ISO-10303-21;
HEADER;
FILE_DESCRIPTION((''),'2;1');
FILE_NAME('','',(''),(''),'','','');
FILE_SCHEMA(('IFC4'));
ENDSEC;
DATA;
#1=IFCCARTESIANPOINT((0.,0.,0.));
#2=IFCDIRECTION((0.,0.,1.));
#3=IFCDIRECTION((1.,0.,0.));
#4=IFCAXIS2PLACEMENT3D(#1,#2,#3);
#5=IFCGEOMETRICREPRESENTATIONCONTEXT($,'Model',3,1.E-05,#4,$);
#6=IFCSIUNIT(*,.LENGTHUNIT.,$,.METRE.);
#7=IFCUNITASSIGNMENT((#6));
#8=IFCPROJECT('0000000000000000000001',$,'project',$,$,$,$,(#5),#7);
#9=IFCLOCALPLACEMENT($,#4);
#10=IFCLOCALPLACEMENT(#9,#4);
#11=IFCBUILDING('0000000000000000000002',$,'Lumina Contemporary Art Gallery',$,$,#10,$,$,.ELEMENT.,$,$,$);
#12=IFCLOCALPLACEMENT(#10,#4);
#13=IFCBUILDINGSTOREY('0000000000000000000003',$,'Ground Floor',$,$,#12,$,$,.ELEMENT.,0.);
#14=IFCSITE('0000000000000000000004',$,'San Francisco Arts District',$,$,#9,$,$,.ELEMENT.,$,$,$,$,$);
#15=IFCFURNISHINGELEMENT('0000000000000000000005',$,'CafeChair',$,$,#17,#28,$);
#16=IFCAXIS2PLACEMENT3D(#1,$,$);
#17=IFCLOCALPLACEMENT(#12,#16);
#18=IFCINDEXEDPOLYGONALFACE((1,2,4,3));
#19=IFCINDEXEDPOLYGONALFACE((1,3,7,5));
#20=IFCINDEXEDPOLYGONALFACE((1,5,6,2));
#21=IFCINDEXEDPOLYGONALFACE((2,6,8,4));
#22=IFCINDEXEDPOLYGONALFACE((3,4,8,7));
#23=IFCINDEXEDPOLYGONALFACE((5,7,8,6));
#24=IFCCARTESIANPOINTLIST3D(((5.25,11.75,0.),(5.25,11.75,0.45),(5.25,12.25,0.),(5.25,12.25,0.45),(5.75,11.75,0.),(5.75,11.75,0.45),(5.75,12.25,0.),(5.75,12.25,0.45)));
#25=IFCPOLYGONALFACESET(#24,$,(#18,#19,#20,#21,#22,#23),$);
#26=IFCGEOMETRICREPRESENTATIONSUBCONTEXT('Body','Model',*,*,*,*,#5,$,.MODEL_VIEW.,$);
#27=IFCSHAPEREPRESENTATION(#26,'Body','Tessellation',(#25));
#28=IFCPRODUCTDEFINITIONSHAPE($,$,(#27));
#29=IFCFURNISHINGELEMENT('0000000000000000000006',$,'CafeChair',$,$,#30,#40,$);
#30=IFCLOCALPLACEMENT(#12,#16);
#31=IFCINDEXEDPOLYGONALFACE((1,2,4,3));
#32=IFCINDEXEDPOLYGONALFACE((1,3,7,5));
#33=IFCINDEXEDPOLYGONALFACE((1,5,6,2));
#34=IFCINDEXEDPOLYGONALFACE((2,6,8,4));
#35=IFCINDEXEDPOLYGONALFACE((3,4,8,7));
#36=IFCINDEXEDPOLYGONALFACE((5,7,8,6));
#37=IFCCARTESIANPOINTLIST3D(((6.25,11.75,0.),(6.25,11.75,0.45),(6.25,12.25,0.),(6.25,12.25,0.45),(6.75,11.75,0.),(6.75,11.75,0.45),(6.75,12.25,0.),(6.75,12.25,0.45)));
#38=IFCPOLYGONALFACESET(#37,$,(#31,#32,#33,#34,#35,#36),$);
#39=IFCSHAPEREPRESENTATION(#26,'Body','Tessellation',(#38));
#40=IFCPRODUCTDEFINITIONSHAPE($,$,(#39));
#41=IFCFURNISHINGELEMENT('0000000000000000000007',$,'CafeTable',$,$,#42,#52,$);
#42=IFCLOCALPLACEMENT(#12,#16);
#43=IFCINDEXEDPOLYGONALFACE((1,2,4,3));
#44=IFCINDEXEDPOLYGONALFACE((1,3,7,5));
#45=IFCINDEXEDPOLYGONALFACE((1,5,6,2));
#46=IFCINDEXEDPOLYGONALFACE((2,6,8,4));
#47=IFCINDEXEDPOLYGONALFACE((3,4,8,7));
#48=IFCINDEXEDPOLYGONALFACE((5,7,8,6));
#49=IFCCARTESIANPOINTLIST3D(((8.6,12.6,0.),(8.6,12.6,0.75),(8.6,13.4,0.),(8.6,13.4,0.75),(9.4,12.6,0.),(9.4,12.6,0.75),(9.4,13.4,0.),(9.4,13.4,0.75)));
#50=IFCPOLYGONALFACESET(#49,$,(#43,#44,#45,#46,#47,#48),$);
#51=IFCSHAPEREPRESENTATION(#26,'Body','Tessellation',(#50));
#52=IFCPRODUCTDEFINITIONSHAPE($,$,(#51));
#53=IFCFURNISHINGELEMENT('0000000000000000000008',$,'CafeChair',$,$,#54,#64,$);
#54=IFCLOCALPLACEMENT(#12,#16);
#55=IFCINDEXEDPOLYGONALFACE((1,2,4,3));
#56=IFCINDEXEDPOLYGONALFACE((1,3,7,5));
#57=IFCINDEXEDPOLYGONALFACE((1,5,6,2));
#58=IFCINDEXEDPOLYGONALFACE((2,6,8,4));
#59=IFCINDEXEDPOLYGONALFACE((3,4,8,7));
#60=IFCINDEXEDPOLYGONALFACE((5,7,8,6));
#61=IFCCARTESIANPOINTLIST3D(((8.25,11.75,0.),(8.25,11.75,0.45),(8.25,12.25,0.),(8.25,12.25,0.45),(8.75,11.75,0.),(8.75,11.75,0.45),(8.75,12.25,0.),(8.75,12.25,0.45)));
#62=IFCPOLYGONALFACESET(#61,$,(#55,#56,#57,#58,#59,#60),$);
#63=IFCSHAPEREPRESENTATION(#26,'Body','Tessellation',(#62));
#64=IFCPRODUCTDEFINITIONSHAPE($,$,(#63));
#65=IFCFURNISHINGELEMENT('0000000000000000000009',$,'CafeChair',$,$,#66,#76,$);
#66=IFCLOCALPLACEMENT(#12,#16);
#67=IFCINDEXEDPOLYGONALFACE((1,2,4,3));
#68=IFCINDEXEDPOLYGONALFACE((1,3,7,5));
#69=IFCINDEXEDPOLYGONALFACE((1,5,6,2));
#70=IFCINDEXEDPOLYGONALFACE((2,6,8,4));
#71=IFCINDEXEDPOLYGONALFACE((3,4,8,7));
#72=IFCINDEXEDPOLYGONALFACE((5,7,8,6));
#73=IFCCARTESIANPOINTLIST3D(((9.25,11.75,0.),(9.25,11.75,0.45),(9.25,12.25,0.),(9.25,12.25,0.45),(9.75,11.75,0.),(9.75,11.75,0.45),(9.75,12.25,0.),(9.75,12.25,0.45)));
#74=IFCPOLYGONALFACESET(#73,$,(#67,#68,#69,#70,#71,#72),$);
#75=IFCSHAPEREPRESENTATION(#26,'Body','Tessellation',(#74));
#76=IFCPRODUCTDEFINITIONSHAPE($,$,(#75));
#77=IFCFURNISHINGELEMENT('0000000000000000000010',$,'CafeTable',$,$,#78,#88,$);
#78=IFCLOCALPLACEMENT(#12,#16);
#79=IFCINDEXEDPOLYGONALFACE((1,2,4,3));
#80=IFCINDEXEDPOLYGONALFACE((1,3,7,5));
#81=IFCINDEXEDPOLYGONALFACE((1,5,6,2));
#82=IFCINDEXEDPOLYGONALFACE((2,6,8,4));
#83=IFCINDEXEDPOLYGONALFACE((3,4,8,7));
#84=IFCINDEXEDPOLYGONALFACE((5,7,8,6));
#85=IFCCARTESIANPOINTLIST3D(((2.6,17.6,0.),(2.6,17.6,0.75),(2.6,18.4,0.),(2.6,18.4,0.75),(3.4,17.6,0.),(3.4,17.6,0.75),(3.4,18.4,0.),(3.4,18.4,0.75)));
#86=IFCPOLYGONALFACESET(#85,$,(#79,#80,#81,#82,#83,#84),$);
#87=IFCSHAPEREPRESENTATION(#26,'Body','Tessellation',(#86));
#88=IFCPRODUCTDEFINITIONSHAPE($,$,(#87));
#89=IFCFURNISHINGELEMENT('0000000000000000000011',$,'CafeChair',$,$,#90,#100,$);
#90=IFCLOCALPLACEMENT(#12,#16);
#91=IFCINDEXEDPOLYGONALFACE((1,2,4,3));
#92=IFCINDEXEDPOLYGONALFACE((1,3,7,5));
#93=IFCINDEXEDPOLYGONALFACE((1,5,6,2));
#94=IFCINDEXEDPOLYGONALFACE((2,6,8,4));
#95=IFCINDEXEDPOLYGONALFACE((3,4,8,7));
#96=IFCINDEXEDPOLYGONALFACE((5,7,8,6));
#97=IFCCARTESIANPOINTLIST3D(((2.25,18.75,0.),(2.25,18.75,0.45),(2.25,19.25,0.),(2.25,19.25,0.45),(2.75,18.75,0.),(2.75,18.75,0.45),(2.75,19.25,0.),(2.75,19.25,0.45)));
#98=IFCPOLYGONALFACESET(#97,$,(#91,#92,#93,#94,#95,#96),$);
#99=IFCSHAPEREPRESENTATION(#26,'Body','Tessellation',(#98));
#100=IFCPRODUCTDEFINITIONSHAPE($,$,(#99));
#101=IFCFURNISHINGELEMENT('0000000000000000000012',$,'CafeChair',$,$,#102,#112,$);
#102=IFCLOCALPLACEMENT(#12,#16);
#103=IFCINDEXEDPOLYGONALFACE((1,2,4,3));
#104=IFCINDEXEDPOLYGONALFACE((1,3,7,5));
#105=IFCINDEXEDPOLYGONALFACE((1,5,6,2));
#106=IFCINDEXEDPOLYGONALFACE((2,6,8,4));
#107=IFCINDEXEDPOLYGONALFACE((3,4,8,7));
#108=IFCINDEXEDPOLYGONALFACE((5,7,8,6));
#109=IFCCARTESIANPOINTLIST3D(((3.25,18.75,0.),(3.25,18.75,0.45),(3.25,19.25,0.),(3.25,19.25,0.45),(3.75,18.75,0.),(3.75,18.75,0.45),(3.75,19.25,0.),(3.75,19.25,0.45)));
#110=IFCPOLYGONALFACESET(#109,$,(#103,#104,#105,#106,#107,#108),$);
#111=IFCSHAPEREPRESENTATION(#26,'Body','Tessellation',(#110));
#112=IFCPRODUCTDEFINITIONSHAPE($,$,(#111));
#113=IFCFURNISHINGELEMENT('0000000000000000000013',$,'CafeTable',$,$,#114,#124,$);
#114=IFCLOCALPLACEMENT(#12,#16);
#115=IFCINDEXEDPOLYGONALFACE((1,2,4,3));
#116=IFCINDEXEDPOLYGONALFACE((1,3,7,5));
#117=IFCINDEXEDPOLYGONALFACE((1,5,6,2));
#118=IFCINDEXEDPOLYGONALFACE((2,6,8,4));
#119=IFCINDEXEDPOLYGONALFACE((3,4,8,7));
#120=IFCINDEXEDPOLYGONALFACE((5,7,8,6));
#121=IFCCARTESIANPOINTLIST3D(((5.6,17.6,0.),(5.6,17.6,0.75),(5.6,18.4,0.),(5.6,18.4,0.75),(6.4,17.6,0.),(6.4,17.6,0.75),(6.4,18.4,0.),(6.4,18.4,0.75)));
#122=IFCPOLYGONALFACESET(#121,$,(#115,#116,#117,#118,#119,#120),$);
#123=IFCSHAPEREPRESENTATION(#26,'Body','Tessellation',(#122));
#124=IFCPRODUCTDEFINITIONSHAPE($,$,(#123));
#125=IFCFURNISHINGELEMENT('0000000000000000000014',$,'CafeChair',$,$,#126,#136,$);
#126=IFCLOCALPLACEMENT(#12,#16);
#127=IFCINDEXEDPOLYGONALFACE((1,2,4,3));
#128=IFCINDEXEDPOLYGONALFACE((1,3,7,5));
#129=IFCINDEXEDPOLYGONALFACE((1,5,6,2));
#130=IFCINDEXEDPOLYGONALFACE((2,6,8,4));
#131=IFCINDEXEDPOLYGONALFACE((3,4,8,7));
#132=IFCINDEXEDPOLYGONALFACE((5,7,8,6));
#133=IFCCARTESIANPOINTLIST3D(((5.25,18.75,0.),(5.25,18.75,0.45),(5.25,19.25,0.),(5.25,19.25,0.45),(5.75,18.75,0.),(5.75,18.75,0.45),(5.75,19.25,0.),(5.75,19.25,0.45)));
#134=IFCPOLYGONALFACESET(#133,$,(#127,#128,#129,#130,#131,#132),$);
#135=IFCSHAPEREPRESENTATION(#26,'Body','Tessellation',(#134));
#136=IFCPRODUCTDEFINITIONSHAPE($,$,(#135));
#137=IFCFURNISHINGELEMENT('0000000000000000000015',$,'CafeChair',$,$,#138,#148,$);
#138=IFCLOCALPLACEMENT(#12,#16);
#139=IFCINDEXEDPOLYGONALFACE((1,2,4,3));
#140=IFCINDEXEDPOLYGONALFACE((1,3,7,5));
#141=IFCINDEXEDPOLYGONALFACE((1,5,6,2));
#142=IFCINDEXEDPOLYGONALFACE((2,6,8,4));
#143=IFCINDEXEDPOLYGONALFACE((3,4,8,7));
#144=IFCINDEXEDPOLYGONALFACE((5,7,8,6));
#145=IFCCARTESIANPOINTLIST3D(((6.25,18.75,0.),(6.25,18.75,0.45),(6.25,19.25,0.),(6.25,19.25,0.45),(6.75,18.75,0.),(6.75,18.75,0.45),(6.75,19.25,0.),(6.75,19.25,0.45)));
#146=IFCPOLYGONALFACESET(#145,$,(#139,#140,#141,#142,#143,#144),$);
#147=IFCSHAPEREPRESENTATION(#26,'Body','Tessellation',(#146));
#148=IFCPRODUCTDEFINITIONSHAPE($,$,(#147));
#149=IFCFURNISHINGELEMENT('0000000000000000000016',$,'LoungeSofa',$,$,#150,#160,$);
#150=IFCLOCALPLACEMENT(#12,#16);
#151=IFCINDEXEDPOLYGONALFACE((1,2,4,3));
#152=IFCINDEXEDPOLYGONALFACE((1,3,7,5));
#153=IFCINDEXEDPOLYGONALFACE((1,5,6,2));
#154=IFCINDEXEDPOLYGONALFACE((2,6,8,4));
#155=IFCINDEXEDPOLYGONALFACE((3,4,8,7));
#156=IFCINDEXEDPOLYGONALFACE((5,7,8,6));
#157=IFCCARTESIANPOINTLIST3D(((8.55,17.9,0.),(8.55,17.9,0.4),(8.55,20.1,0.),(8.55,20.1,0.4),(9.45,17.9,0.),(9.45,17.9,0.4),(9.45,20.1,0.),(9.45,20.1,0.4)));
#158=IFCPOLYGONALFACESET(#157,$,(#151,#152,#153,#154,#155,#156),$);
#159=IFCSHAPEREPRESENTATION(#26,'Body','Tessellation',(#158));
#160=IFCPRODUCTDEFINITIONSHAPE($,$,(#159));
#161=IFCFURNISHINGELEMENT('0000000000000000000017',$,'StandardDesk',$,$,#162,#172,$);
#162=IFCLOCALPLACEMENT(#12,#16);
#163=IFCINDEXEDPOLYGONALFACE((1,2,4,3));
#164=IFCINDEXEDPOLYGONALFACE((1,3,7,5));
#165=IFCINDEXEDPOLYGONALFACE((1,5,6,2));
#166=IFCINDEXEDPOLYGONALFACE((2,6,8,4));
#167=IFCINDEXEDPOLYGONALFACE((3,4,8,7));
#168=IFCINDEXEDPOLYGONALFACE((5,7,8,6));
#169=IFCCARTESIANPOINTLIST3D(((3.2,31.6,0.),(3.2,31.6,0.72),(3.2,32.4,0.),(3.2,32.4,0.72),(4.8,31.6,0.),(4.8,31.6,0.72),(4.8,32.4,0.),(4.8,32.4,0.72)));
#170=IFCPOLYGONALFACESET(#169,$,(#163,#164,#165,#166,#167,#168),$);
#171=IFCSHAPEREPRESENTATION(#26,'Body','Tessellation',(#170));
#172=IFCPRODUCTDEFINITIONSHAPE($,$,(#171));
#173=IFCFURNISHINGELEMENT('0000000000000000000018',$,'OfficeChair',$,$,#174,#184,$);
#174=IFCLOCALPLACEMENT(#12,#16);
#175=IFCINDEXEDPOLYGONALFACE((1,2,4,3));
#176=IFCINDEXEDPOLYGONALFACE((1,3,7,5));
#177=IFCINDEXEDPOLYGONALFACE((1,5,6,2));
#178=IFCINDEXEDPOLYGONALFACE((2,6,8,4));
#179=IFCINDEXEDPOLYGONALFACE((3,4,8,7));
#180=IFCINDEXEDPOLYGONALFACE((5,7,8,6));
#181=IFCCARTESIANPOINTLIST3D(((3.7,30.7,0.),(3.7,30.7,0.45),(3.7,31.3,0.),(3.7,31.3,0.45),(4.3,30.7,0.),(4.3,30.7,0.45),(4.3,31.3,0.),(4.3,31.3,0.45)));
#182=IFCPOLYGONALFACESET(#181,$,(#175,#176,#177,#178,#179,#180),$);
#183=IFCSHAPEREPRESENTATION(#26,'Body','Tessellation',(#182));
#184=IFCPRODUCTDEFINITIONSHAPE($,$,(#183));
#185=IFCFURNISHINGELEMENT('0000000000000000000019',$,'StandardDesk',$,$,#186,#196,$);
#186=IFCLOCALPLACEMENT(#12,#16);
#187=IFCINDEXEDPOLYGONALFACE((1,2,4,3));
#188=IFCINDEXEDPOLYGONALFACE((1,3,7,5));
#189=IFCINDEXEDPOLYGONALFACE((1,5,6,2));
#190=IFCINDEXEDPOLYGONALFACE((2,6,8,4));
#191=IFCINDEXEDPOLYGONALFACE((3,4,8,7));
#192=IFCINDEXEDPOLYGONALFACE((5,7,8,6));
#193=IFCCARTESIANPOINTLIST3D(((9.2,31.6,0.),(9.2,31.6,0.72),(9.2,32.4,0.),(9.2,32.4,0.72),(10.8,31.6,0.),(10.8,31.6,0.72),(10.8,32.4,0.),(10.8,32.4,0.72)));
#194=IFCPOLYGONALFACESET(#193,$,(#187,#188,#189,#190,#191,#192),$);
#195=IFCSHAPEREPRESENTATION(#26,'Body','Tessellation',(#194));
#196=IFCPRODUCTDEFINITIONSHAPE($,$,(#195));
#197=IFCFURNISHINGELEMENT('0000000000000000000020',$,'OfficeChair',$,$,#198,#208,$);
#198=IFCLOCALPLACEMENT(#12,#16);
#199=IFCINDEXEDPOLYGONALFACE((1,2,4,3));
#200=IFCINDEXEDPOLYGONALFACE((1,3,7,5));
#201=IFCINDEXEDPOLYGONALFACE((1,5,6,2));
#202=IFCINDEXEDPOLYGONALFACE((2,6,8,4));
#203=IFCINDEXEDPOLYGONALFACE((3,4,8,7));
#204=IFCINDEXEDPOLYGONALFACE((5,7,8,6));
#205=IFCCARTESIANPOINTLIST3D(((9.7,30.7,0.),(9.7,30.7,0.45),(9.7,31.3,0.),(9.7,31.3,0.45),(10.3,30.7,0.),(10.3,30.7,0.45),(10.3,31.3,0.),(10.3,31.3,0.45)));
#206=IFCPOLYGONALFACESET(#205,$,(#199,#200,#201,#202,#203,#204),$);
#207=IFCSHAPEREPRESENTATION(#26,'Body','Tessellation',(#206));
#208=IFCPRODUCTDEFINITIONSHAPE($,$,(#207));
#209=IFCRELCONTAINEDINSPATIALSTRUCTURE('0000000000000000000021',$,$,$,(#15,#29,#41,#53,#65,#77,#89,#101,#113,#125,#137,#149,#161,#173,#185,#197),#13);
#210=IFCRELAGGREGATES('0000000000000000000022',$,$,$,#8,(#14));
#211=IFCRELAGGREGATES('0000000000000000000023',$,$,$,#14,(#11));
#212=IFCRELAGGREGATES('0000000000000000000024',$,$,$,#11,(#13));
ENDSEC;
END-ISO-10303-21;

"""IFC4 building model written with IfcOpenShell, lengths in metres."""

from ifc_helpers import new_model, si_unit, origin_with_axes, place, context, subcontext, project, spatial, polyline, outline, extrude, element, save


model = new_model("IFC4")

# Units and contexts
model_context = context("Model", 3, precision=1e-05, world=origin_with_axes())
body_context = subcontext(model_context, "Body", "Model", "MODEL_VIEW")
ifc_project = project(units=[si_unit("LENGTHUNIT", "METRE")], contexts=[model_context])

# Site, building, storey
site_placement = place(None, origin_with_axes())
site = spatial("IfcSite", under=ifc_project, at=site_placement, Name="San Francisco Arts District", CompositionType="ELEMENT")
building_placement = place(site_placement, origin_with_axes())
building = spatial("IfcBuilding", under=site, at=building_placement, Name="Lumina Contemporary Art Gallery", CompositionType="ELEMENT")
storey_placement = place(building_placement, origin_with_axes())
storey = spatial("IfcBuildingStorey", under=building, at=storey_placement, Name="Ground Floor", CompositionType="ELEMENT", Elevation=0.0)

# Furnishing elements
furnishing_1_placement = place(storey_placement, origin_with_axes())
element("IfcFurnishingElement", 1, at=furnishing_1_placement, inside=storey, Name="CafeChair", context=body_context, shape_type="SweptSolid", body=[
    extrude(outline(polyline([(5.25, 11.75, 0.0), (5.75, 11.75, 0.0), (5.75, 12.25, 0.0), (5.25, 12.25, 0.0), (5.25, 11.75, 0.0)])), None, (0.0, 0.0, 1.0), 0.45),
])
furnishing_2_placement = place(storey_placement, origin_with_axes())
element("IfcFurnishingElement", 2, at=furnishing_2_placement, inside=storey, Name="CafeChair", context=body_context, shape_type="SweptSolid", body=[
    extrude(outline(polyline([(6.25, 11.75, 0.0), (6.75, 11.75, 0.0), (6.75, 12.25, 0.0), (6.25, 12.25, 0.0), (6.25, 11.75, 0.0)])), None, (0.0, 0.0, 1.0), 0.45),
])
furnishing_3_placement = place(storey_placement, origin_with_axes())
element("IfcFurnishingElement", 3, at=furnishing_3_placement, inside=storey, Name="CafeTable", context=body_context, shape_type="SweptSolid", body=[
    extrude(outline(polyline([(8.6, 12.6, 0.0), (9.4, 12.6, 0.0), (9.4, 13.4, 0.0), (8.6, 13.4, 0.0), (8.6, 12.6, 0.0)])), None, (0.0, 0.0, 1.0), 0.75),
])
furnishing_4_placement = place(storey_placement, origin_with_axes())
element("IfcFurnishingElement", 4, at=furnishing_4_placement, inside=storey, Name="CafeChair", context=body_context, shape_type="SweptSolid", body=[
    extrude(outline(polyline([(8.25, 11.75, 0.0), (8.75, 11.75, 0.0), (8.75, 12.25, 0.0), (8.25, 12.25, 0.0), (8.25, 11.75, 0.0)])), None, (0.0, 0.0, 1.0), 0.45),
])
furnishing_5_placement = place(storey_placement, origin_with_axes())
element("IfcFurnishingElement", 5, at=furnishing_5_placement, inside=storey, Name="CafeChair", context=body_context, shape_type="SweptSolid", body=[
    extrude(outline(polyline([(9.25, 11.75, 0.0), (9.75, 11.75, 0.0), (9.75, 12.25, 0.0), (9.25, 12.25, 0.0), (9.25, 11.75, 0.0)])), None, (0.0, 0.0, 1.0), 0.45),
])
furnishing_6_placement = place(storey_placement, origin_with_axes())
element("IfcFurnishingElement", 6, at=furnishing_6_placement, inside=storey, Name="CafeTable", context=body_context, shape_type="SweptSolid", body=[
    extrude(outline(polyline([(3.4, 18.4, 0.0), (2.6, 18.4, 0.0), (2.6, 17.6, 0.0), (3.4, 17.6, 0.0), (3.4, 18.4, 0.0)])), None, (0.0, 0.0, 1.0), 0.75),
])
furnishing_7_placement = place(storey_placement, origin_with_axes())
element("IfcFurnishingElement", 7, at=furnishing_7_placement, inside=storey, Name="CafeChair", context=body_context, shape_type="SweptSolid", body=[
    extrude(outline(polyline([(2.75, 19.25, 0.0), (2.25, 19.25, 0.0), (2.25, 18.75, 0.0), (2.75, 18.75, 0.0), (2.75, 19.25, 0.0)])), None, (0.0, 0.0, 1.0), 0.45),
])
furnishing_8_placement = place(storey_placement, origin_with_axes())
element("IfcFurnishingElement", 8, at=furnishing_8_placement, inside=storey, Name="CafeChair", context=body_context, shape_type="SweptSolid", body=[
    extrude(outline(polyline([(3.75, 19.25, 0.0), (3.25, 19.25, 0.0), (3.25, 18.75, 0.0), (3.75, 18.75, 0.0), (3.75, 19.25, 0.0)])), None, (0.0, 0.0, 1.0), 0.45),
])
furnishing_9_placement = place(storey_placement, origin_with_axes())
element("IfcFurnishingElement", 9, at=furnishing_9_placement, inside=storey, Name="CafeTable", context=body_context, shape_type="SweptSolid", body=[
    extrude(outline(polyline([(6.4, 18.4, 0.0), (5.6, 18.4, 0.0), (5.6, 17.6, 0.0), (6.4, 17.6, 0.0), (6.4, 18.4, 0.0)])), None, (0.0, 0.0, 1.0), 0.75),
])
furnishing_10_placement = place(storey_placement, origin_with_axes())
element("IfcFurnishingElement", 10, at=furnishing_10_placement, inside=storey, Name="CafeChair", context=body_context, shape_type="SweptSolid", body=[
    extrude(outline(polyline([(5.75, 19.25, 0.0), (5.25, 19.25, 0.0), (5.25, 18.75, 0.0), (5.75, 18.75, 0.0), (5.75, 19.25, 0.0)])), None, (0.0, 0.0, 1.0), 0.45),
])
furnishing_11_placement = place(storey_placement, origin_with_axes())
element("IfcFurnishingElement", 11, at=furnishing_11_placement, inside=storey, Name="CafeChair", context=body_context, shape_type="SweptSolid", body=[
    extrude(outline(polyline([(6.75, 19.25, 0.0), (6.25, 19.25, 0.0), (6.25, 18.75, 0.0), (6.75, 18.75, 0.0), (6.75, 19.25, 0.0)])), None, (0.0, 0.0, 1.0), 0.45),
])
furnishing_12_placement = place(storey_placement, origin_with_axes())
element("IfcFurnishingElement", 12, at=furnishing_12_placement, inside=storey, Name="LoungeSofa", context=body_context, shape_type="SweptSolid", body=[
    extrude(outline(polyline([(9.45, 17.9, 0.0), (9.45, 20.1, 0.0), (8.55, 20.1, 0.0), (8.55, 17.9, 0.0), (9.45, 17.9, 0.0)])), None, (0.0, 0.0, 1.0), 0.4),
])
furnishing_13_placement = place(storey_placement, origin_with_axes())
element("IfcFurnishingElement", 13, at=furnishing_13_placement, inside=storey, Name="StandardDesk", context=body_context, shape_type="SweptSolid", body=[
    extrude(outline(polyline([(4.8, 32.4, 0.0), (3.2, 32.4, 0.0), (3.2, 31.6, 0.0), (4.8, 31.6, 0.0), (4.8, 32.4, 0.0)])), None, (0.0, 0.0, 1.0), 0.72),
])
furnishing_14_placement = place(storey_placement, origin_with_axes())
element("IfcFurnishingElement", 14, at=furnishing_14_placement, inside=storey, Name="OfficeChair", context=body_context, shape_type="SweptSolid", body=[
    extrude(outline(polyline([(3.7, 30.7, 0.0), (4.3, 30.7, 0.0), (4.3, 31.3, 0.0), (3.7, 31.3, 0.0), (3.7, 30.7, 0.0)])), None, (0.0, 0.0, 1.0), 0.45),
])
furnishing_15_placement = place(storey_placement, origin_with_axes())
element("IfcFurnishingElement", 15, at=furnishing_15_placement, inside=storey, Name="StandardDesk", context=body_context, shape_type="SweptSolid", body=[
    extrude(outline(polyline([(10.8, 32.4, 0.0), (9.2, 32.4, 0.0), (9.2, 31.6, 0.0), (10.8, 31.6, 0.0), (10.8, 32.4, 0.0)])), None, (0.0, 0.0, 1.0), 0.72),
])
furnishing_16_placement = place(storey_placement, origin_with_axes())
element("IfcFurnishingElement", 16, at=furnishing_16_placement, inside=storey, Name="OfficeChair", context=body_context, shape_type="SweptSolid", body=[
    extrude(outline(polyline([(9.7, 30.7, 0.0), (10.3, 30.7, 0.0), (10.3, 31.3, 0.0), (9.7, 31.3, 0.0), (9.7, 30.7, 0.0)])), None, (0.0, 0.0, 1.0), 0.45),
])

save(model, "model.ifc")
